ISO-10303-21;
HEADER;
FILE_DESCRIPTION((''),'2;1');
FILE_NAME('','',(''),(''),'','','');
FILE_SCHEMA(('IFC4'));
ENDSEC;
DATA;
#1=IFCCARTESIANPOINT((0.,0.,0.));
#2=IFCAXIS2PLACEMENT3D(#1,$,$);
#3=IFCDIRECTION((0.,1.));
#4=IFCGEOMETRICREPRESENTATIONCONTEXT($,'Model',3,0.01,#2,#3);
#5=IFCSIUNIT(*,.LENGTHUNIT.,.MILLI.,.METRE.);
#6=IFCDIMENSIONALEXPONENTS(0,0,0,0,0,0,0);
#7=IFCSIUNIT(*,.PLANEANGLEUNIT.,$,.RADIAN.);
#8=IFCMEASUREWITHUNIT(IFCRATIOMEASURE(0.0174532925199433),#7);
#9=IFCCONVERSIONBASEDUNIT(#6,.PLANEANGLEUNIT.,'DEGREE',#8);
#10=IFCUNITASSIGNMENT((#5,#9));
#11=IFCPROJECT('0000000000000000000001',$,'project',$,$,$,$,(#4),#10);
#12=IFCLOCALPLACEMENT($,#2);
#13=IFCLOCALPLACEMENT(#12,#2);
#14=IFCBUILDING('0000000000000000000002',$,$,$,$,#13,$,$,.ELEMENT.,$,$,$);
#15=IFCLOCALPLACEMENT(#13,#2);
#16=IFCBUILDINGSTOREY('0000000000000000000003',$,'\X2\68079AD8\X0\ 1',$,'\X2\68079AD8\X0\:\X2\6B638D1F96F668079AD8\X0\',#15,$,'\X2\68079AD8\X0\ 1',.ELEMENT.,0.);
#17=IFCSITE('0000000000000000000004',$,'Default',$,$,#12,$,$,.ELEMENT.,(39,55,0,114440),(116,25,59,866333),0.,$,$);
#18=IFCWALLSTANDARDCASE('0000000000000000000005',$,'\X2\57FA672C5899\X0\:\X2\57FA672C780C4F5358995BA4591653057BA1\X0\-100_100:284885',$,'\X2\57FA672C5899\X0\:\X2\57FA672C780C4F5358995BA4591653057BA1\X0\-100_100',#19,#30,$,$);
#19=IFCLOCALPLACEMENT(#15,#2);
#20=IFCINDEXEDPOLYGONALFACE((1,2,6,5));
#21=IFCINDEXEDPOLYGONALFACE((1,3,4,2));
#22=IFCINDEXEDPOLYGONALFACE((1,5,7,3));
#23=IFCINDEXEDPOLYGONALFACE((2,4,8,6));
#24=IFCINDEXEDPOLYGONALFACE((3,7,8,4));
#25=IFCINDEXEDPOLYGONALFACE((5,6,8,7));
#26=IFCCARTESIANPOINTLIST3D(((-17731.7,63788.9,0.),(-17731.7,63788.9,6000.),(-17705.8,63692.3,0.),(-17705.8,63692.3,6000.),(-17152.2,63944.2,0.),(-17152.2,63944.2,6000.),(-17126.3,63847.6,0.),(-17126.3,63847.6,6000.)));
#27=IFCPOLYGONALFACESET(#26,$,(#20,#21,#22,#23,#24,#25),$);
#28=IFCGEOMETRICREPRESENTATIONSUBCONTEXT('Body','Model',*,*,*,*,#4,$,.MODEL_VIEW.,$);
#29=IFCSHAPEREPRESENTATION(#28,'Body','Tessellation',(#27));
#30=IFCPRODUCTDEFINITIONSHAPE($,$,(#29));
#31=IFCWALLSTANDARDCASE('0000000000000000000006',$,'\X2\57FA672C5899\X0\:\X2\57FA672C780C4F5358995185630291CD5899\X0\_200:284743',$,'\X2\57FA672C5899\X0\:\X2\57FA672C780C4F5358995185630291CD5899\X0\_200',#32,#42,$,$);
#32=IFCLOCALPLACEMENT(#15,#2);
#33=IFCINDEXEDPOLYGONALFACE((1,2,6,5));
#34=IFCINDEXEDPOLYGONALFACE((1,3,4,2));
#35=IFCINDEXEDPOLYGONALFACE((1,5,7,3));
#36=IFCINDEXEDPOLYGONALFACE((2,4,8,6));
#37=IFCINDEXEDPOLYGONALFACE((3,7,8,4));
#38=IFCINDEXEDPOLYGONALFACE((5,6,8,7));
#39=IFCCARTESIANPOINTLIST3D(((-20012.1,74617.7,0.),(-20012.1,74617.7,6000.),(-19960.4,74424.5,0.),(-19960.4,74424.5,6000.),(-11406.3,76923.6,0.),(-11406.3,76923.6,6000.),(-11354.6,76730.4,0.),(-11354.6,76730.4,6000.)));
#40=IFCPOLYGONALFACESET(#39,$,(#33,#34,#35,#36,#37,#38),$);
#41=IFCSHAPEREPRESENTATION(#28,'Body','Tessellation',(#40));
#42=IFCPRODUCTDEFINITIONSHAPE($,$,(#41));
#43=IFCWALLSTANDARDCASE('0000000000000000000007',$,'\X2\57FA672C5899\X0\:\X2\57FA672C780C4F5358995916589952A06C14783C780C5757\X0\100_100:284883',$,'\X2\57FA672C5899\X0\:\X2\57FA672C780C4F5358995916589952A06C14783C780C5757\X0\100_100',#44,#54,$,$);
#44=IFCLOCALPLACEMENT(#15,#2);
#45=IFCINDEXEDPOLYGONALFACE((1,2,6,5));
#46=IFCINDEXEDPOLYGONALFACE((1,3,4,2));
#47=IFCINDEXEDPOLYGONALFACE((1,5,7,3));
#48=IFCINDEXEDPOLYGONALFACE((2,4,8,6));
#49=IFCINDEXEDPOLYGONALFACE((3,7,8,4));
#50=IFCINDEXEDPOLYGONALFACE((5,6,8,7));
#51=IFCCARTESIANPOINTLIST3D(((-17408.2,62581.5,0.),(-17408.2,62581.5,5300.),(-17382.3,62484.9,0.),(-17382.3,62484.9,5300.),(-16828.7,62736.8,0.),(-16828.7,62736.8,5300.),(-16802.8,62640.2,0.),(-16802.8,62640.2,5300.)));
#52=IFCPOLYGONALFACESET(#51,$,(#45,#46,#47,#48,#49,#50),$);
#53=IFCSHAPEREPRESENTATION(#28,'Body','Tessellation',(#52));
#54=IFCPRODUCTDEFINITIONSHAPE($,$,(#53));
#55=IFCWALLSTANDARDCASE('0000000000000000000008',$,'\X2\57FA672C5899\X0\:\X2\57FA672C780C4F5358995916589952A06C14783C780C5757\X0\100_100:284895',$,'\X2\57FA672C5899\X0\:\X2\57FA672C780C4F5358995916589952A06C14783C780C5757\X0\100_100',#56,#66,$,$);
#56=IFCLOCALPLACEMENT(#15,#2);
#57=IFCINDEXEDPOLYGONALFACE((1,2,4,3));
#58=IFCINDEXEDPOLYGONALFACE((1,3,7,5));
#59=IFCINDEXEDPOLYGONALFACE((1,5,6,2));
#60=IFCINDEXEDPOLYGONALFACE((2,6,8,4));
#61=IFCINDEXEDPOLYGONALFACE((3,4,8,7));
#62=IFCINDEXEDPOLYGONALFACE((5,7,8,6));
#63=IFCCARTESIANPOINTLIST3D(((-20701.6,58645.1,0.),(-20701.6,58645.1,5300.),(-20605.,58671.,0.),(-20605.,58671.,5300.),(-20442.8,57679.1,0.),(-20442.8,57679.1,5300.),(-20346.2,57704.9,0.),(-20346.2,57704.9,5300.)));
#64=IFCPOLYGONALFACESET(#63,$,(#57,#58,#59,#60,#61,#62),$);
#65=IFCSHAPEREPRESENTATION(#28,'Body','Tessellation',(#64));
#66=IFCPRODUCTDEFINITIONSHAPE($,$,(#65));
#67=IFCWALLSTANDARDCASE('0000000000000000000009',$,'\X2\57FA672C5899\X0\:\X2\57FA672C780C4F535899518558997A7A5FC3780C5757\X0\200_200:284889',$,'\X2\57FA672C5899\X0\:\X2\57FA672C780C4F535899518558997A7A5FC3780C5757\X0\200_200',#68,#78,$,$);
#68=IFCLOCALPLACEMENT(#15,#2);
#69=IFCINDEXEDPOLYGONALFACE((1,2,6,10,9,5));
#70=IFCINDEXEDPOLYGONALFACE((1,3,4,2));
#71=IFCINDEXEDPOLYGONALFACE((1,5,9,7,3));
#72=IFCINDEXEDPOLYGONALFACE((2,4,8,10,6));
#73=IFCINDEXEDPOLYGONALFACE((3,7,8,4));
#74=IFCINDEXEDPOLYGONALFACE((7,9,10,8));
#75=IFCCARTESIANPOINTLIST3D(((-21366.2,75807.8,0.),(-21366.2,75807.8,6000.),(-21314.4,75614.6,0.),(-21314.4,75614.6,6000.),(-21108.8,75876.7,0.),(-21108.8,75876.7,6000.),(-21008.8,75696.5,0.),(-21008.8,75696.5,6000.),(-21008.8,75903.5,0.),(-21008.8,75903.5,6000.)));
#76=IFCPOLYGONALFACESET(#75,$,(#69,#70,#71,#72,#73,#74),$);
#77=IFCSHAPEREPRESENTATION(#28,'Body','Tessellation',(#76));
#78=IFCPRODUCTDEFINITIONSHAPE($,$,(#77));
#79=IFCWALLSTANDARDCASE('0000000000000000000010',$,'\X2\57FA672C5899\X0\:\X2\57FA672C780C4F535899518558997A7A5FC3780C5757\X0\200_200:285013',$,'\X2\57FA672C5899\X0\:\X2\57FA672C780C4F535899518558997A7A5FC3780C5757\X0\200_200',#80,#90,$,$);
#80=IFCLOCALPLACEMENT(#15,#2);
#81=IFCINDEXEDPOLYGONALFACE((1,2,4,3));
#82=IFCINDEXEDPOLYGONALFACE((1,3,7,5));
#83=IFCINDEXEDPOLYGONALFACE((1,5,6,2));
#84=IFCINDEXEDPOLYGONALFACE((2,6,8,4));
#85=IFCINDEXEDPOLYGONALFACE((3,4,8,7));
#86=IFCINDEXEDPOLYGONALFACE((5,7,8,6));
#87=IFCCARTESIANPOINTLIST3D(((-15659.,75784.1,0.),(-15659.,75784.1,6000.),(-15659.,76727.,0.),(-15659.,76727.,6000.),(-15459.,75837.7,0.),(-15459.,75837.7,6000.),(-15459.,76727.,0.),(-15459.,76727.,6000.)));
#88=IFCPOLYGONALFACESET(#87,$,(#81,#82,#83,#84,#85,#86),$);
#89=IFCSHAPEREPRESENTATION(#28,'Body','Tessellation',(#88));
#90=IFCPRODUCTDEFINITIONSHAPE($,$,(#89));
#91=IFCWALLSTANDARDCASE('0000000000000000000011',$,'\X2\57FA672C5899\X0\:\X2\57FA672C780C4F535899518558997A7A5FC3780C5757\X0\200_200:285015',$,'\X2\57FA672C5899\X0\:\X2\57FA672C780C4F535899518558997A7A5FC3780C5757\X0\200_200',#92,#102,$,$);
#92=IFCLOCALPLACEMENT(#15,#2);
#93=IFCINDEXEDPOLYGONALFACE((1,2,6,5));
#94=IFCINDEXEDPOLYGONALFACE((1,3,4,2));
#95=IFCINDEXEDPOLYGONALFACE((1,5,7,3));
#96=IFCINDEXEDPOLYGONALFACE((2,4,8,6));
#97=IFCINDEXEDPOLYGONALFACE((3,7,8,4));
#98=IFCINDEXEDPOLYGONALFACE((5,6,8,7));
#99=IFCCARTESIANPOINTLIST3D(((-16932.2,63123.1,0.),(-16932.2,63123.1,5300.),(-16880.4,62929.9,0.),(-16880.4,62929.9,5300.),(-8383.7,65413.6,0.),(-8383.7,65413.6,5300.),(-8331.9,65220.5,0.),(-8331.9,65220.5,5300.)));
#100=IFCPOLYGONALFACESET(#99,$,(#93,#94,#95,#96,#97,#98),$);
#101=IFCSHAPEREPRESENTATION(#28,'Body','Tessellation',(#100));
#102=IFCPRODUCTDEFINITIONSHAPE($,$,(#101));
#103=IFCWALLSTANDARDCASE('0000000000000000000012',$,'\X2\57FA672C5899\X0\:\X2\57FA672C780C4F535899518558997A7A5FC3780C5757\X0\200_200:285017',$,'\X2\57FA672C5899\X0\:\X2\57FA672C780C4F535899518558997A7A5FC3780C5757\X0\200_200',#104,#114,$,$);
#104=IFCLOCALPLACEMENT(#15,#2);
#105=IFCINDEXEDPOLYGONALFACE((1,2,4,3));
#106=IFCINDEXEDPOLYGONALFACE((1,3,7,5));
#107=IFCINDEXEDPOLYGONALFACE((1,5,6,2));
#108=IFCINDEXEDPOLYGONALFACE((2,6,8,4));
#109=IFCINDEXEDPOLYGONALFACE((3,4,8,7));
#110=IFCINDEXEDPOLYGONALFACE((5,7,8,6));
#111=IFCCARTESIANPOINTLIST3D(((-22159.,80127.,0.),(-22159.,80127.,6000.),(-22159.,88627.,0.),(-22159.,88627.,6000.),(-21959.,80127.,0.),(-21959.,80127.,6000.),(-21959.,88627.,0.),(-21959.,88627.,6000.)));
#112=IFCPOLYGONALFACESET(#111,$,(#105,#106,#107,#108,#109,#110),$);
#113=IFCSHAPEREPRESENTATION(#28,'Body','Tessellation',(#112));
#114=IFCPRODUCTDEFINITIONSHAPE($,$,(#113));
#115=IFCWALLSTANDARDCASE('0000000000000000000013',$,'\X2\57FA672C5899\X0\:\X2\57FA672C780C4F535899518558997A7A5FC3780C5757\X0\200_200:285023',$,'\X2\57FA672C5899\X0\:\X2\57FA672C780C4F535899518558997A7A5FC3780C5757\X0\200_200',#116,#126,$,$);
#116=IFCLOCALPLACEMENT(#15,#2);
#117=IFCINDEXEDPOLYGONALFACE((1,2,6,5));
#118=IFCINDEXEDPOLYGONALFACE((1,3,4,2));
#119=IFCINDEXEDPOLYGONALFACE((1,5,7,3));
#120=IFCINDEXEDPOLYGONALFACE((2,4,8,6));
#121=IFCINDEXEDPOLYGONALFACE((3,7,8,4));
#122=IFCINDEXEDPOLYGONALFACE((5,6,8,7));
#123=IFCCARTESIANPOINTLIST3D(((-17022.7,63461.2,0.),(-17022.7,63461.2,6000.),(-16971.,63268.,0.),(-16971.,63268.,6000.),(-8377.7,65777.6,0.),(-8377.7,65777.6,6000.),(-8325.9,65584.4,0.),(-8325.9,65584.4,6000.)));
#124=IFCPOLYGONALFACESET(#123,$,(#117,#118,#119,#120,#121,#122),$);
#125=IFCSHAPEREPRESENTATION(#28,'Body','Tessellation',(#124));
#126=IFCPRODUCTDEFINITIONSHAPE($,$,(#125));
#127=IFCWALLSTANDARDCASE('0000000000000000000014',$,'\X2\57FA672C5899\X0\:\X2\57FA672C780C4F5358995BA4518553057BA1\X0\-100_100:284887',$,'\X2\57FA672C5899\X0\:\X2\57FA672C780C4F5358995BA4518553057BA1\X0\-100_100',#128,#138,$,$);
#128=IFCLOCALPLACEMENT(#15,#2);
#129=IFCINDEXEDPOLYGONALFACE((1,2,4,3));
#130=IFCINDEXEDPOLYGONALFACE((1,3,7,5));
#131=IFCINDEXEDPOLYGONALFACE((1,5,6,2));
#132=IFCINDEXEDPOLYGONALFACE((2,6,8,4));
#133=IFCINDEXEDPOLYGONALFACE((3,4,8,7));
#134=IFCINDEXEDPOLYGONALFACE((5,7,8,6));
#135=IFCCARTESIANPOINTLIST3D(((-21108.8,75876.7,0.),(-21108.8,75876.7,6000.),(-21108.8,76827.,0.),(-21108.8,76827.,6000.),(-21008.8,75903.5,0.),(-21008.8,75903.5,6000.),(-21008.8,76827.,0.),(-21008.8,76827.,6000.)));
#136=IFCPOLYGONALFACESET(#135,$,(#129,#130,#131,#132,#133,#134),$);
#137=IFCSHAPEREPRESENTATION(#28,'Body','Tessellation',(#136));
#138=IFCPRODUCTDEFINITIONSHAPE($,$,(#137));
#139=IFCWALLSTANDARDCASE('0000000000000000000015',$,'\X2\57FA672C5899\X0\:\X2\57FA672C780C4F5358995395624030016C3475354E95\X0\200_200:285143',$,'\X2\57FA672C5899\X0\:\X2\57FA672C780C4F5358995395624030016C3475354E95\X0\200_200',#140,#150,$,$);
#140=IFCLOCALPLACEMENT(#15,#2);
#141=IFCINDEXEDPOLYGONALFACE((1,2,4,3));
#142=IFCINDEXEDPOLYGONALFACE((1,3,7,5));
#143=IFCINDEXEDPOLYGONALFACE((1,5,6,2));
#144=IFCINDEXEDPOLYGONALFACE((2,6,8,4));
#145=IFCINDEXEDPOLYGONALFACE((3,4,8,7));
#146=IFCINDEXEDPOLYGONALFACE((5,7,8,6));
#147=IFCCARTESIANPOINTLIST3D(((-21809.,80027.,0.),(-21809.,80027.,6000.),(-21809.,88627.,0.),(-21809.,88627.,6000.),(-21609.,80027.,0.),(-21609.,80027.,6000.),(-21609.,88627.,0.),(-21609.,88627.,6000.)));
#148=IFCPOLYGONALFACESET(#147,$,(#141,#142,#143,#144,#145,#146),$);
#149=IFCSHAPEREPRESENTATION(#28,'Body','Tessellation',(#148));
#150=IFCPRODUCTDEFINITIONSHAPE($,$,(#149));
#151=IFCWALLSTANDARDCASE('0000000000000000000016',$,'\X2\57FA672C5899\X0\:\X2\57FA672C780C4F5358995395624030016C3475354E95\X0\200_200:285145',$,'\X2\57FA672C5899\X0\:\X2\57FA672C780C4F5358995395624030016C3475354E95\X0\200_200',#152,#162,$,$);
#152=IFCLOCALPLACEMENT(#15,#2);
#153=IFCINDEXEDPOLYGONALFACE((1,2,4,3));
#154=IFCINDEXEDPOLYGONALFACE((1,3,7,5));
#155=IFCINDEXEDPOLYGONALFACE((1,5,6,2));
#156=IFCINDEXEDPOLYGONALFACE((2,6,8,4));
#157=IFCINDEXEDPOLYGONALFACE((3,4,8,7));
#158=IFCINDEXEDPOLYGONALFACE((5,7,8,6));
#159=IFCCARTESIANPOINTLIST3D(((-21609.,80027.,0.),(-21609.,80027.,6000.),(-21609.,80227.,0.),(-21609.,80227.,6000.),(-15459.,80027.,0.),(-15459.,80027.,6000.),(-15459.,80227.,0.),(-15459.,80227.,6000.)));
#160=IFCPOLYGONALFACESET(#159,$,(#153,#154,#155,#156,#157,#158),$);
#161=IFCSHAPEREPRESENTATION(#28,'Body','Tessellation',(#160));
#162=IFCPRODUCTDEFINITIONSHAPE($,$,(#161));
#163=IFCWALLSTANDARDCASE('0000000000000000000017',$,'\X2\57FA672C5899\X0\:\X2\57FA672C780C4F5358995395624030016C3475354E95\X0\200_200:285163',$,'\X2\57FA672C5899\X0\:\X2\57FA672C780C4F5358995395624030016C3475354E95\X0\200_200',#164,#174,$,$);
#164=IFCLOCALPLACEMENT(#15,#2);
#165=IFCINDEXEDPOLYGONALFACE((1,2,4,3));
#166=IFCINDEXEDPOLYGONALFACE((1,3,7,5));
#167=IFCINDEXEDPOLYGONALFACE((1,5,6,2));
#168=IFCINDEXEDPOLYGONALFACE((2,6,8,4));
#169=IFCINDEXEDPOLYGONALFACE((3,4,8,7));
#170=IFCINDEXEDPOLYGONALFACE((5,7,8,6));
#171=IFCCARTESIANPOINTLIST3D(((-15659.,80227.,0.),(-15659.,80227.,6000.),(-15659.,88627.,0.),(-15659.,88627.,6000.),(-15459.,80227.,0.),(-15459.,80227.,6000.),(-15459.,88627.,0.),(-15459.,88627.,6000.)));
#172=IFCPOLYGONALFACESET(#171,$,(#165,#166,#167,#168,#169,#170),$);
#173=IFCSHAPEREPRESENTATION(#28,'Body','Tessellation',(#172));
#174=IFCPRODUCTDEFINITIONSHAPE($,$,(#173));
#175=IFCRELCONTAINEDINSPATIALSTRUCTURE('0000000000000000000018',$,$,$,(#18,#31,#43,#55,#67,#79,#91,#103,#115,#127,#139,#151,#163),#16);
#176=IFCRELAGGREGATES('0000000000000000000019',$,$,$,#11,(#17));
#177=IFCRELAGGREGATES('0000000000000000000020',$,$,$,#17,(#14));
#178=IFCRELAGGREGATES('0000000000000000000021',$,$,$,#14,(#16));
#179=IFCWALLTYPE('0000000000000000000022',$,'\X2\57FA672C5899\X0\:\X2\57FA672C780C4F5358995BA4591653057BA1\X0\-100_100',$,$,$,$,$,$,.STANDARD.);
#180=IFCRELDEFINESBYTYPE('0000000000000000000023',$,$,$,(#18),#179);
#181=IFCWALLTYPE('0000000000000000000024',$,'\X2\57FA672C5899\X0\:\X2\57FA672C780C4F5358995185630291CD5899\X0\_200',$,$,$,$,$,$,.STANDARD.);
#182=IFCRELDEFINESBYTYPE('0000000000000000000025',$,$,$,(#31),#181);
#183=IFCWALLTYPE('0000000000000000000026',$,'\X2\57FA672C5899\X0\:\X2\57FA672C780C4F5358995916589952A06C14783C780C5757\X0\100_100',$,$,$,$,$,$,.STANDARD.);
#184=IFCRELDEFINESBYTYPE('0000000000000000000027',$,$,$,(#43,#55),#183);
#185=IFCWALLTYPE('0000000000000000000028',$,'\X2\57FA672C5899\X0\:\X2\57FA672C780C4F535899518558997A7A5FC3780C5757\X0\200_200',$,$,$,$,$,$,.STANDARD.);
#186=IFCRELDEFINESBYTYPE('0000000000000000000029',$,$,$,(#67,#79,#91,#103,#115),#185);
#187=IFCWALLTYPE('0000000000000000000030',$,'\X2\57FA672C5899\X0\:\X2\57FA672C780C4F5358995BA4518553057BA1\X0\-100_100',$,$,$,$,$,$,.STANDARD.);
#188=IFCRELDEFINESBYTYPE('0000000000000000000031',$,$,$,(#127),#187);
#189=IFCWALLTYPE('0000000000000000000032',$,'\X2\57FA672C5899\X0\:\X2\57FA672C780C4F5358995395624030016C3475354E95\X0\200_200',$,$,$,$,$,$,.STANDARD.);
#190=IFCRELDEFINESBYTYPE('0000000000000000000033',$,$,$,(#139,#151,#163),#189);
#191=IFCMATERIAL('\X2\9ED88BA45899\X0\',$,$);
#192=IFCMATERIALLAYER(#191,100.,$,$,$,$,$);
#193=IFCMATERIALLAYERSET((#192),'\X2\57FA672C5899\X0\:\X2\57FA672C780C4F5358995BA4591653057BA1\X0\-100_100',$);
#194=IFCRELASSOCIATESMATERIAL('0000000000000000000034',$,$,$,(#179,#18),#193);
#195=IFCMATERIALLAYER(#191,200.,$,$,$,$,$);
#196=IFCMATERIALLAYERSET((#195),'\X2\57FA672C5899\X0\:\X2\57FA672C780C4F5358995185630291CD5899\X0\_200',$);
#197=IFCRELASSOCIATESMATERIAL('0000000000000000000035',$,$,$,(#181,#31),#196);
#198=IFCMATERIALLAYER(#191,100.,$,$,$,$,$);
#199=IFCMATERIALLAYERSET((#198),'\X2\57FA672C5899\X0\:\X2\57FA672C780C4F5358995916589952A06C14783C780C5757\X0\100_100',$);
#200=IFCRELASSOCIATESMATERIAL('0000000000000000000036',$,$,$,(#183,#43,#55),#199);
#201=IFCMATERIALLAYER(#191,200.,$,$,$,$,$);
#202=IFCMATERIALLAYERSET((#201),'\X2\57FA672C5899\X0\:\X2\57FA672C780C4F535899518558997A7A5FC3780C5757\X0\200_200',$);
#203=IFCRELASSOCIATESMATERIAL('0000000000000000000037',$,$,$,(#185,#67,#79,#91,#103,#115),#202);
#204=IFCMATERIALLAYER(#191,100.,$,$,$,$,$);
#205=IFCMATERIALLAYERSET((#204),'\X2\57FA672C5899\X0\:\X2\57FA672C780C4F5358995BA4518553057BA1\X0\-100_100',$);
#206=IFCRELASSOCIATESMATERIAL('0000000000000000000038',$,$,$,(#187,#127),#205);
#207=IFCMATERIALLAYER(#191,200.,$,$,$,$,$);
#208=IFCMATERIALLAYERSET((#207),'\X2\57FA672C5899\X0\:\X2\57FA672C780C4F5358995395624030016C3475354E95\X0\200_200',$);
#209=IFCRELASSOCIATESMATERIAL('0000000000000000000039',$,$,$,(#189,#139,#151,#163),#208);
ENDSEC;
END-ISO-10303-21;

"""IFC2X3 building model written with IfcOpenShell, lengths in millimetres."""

from ifc_helpers import new_model, entity, si_unit, converted_unit, direction, frame, frame_2d, origin, place, context, subcontext, project, spatial, polyline, rectangle, outline, extrude, material, layer, layer_set, layer_usage, type_object, element, save


model = new_model("IFC2X3")

# Units and contexts
model_context = context("Model", 3, precision=0.01, world=origin(), true_north=direction((0.0, 1.0)))
body_context = subcontext(model_context, "Body", "Model", "MODEL_VIEW")
ifc_project = project(units=[si_unit("LENGTHUNIT", "METRE", prefix="MILLI"), converted_unit("PLANEANGLEUNIT", "DEGREE", entity("IfcRatioMeasure", 0.0174532925199433), si_unit("PLANEANGLEUNIT", "RADIAN"), dimensions=[0, 0, 0, 0, 0, 0, 0])], contexts=[model_context])

# Site, building, storey
site_placement = place(None, origin())
site = spatial("IfcSite", under=ifc_project, at=site_placement, Name="Default", CompositionType="ELEMENT", RefLatitude=(39, 55, 0, 114440), RefLongitude=(116, 25, 59, 866333), RefElevation=0.0)
building_placement = place(site_placement, origin())
building = spatial("IfcBuilding", under=site, at=building_placement, CompositionType="ELEMENT")
storey_placement = place(building_placement, origin())
storey = spatial("IfcBuildingStorey", under=building, at=storey_placement, Name="标高 1", ObjectType="标高:正负零标高", LongName="标高 1", CompositionType="ELEMENT", Elevation=0.0)

# Walls
ifc_material = material(Name="默认墙")
ifc_layer_1 = layer(ifc_material, 100.0)
ifc_layer_set_1 = layer_set([ifc_layer_1], Name="基本墙:基本砌体墙室外包管-100_100")
ifc_layer_usage_1 = layer_usage(ifc_layer_set_1, "AXIS2", "NEGATIVE", 50.0)
wall_type_1 = type_object("IfcWallType", Name="基本墙:基本砌体墙室外包管-100_100", PredefinedType="STANDARD", material=ifc_layer_set_1)
wall_1_placement = place(building_placement, frame((-17718.8, 63740.6, 0.0), z_axis=(0.0, 0.0, 1.0), x_axis=(0.965926, 0.258819, 0.0)))
element("IfcWallStandardCase", 1, at=wall_1_placement, inside=storey, type_object=wall_type_1, material=ifc_layer_usage_1, Name="基本墙:基本砌体墙室外包管-100_100:284885", ObjectType="基本墙:基本砌体墙室外包管-100_100", context=body_context, shape_type="SweptSolid", body=[
    extrude(rectangle(XDim=600.0, YDim=100.0, at=frame_2d((300.0, 0.0), x_axis=(-1.0, 0.0))), origin(), (0.0, 0.0, 1.0), 6000.0),
])
ifc_layer_2 = layer(ifc_material, 200.0)
ifc_layer_set_2 = layer_set([ifc_layer_2], Name="基本墙:基本砌体墙内挂重墙_200")
ifc_layer_usage_2 = layer_usage(ifc_layer_set_2, "AXIS2", "NEGATIVE", 100.0)
wall_type_2 = type_object("IfcWallType", Name="基本墙:基本砌体墙内挂重墙_200", PredefinedType="STANDARD", material=ifc_layer_set_2)
wall_2_placement = place(building_placement, frame((-19986.2, 74521.1, 0.0), z_axis=(0.0, 0.0, 1.0), x_axis=(0.965926, 0.258819, 0.0)))
element("IfcWallStandardCase", 2, at=wall_2_placement, inside=storey, type_object=wall_type_2, material=ifc_layer_usage_2, Name="基本墙:基本砌体墙内挂重墙_200:284743", ObjectType="基本墙:基本砌体墙内挂重墙_200", context=body_context, shape_type="SweptSolid", body=[
    extrude(rectangle(XDim=8909.4, YDim=200.0, at=frame_2d((4454.7, 0.0), x_axis=(-1.0, 0.0))), origin(), (0.0, 0.0, 1.0), 6000.0),
])
ifc_layer_3 = layer(ifc_material, 100.0)
ifc_layer_set_3 = layer_set([ifc_layer_3], Name="基本墙:基本砌体墙外墙加气砼砌块100_100")
ifc_layer_usage_3 = layer_usage(ifc_layer_set_3, "AXIS2", "NEGATIVE", 50.0)
wall_type_3 = type_object("IfcWallType", Name="基本墙:基本砌体墙外墙加气砼砌块100_100", PredefinedType="STANDARD", material=ifc_layer_set_3)
wall_3_placement = place(building_placement, frame((-17395.3, 62533.2, 0.0), z_axis=(0.0, 0.0, 1.0), x_axis=(0.965926, 0.258819, 0.0)))
element("IfcWallStandardCase", 3, at=wall_3_placement, inside=storey, type_object=wall_type_3, material=ifc_layer_usage_3, Name="基本墙:基本砌体墙外墙加气砼砌块100_100:284883", ObjectType="基本墙:基本砌体墙外墙加气砼砌块100_100", context=body_context, shape_type="SweptSolid", body=[
    extrude(rectangle(XDim=600.0, YDim=100.0, at=frame_2d((300.0, 0.0), x_axis=(-1.0, 0.0))), origin(), (0.0, 0.0, 1.0), 5300.0),
])
ifc_layer_usage_4 = layer_usage(ifc_layer_set_3, "AXIS2", "NEGATIVE", 50.0)
wall_4_placement = place(building_placement, frame((-20394.5, 57692.0, 0.0), z_axis=(0.0, 0.0, 1.0), x_axis=(-0.258819, 0.965926, 0.0)))
element("IfcWallStandardCase", 4, at=wall_4_placement, inside=storey, type_object=wall_type_3, material=ifc_layer_usage_4, Name="基本墙:基本砌体墙外墙加气砼砌块100_100:284895", ObjectType="基本墙:基本砌体墙外墙加气砼砌块100_100", context=body_context, shape_type="SweptSolid", body=[
    extrude(rectangle(XDim=1000.1, YDim=100.0, at=frame_2d((500.0, 0.0), x_axis=(-1.0, 0.0))), origin(), (0.0, 0.0, 1.0), 5300.0),
])
ifc_layer_4 = layer(ifc_material, 200.0)
ifc_layer_set_4 = layer_set([ifc_layer_4], Name="基本墙:基本砌体墙内墙空心砌块200_200")
ifc_layer_usage_5 = layer_usage(ifc_layer_set_4, "AXIS2", "NEGATIVE", 100.0)
wall_type_4 = type_object("IfcWallType", Name="基本墙:基本砌体墙内墙空心砌块200_200", PredefinedType="STANDARD", material=ifc_layer_set_4)
wall_5_placement = place(building_placement, frame((-21340.3, 75711.2, 0.0), z_axis=(0.0, 0.0, 1.0), x_axis=(0.965926, 0.258819, 0.0)))
element("IfcWallStandardCase", 5, at=wall_5_placement, inside=storey, type_object=wall_type_4, material=ifc_layer_usage_5, Name="基本墙:基本砌体墙内墙空心砌块200_200:284889", ObjectType="基本墙:基本砌体墙内墙空心砌块200_200", context=body_context, shape_type="SweptSolid", body=[
    extrude(outline(polyline([(316.4, -100.0), (370.0, 100.0), (266.4, 100.0), (0.0, 100.0), (0.0, -100.0), (316.4, -100.0)])), origin(), (0.0, 0.0, 1.0), 6000.0),
])
ifc_layer_usage_6 = layer_usage(ifc_layer_set_4, "AXIS2", "NEGATIVE", 100.0)
wall_6_placement = place(building_placement, frame((-15559.0, 75784.1, 0.0), z_axis=(0.0, 0.0, 1.0), x_axis=(0.0, 1.0, 0.0)))
element("IfcWallStandardCase", 6, at=wall_6_placement, inside=storey, type_object=wall_type_4, material=ifc_layer_usage_6, Name="基本墙:基本砌体墙内墙空心砌块200_200:285013", ObjectType="基本墙:基本砌体墙内墙空心砌块200_200", context=body_context, shape_type="SweptSolid", body=[
    extrude(outline(polyline([(942.9, -100.0), (942.9, 100.0), (0.0, 100.0), (53.6, -100.0), (942.9, -100.0)])), origin(), (0.0, 0.0, 1.0), 6000.0),
])
ifc_layer_usage_7 = layer_usage(ifc_layer_set_4, "AXIS2", "NEGATIVE", 100.0)
wall_7_placement = place(building_placement, frame((-8357.8, 65317.0, 0.0), z_axis=(0.0, 0.0, 1.0), x_axis=(-0.965926, -0.258819, 0.0)))
element("IfcWallStandardCase", 7, at=wall_7_placement, inside=storey, type_object=wall_type_4, material=ifc_layer_usage_7, Name="基本墙:基本砌体墙内墙空心砌块200_200:285015", ObjectType="基本墙:基本砌体墙内墙空心砌块200_200", context=body_context, shape_type="SweptSolid", body=[
    extrude(rectangle(XDim=8850.0, YDim=200.0, at=frame_2d((4425.0, 0.0), x_axis=(-1.0, 0.0))), origin(), (0.0, 0.0, 1.0), 5300.0),
])
ifc_layer_usage_8 = layer_usage(ifc_layer_set_4, "AXIS2", "NEGATIVE", 100.0)
wall_8_placement = place(building_placement, frame((-22059.0, 80127.0, 0.0), z_axis=(0.0, 0.0, 1.0), x_axis=(0.0, 1.0, 0.0)))
element("IfcWallStandardCase", 8, at=wall_8_placement, inside=storey, type_object=wall_type_4, material=ifc_layer_usage_8, Name="基本墙:基本砌体墙内墙空心砌块200_200:285017", ObjectType="基本墙:基本砌体墙内墙空心砌块200_200", context=body_context, shape_type="SweptSolid", body=[
    extrude(rectangle(XDim=8500.0, YDim=200.0, at=frame_2d((4250.0, 0.0), x_axis=(-1.0, 0.0))), origin(), (0.0, 0.0, 1.0), 6000.0),
])
ifc_layer_usage_9 = layer_usage(ifc_layer_set_4, "AXIS2", "NEGATIVE", 100.0)
wall_9_placement = place(building_placement, frame((-16996.9, 63364.6, 0.0), z_axis=(0.0, 0.0, 1.0), x_axis=(0.965926, 0.258819, 0.0)))
element("IfcWallStandardCase", 9, at=wall_9_placement, inside=storey, type_object=wall_type_4, material=ifc_layer_usage_9, Name="基本墙:基本砌体墙内墙空心砌块200_200:285023", ObjectType="基本墙:基本砌体墙内墙空心砌块200_200", context=body_context, shape_type="SweptSolid", body=[
    extrude(rectangle(XDim=8950.0, YDim=200.0, at=frame_2d((4475.0, 0.0), x_axis=(-1.0, 0.0))), origin(), (0.0, 0.0, 1.0), 6000.0),
])
ifc_layer_5 = layer(ifc_material, 100.0)
ifc_layer_set_5 = layer_set([ifc_layer_5], Name="基本墙:基本砌体墙室内包管-100_100")
ifc_layer_usage_10 = layer_usage(ifc_layer_set_5, "AXIS2", "NEGATIVE", 50.0)
wall_type_5 = type_object("IfcWallType", Name="基本墙:基本砌体墙室内包管-100_100", PredefinedType="STANDARD", material=ifc_layer_set_5)
wall_10_placement = place(building_placement, frame((-21058.8, 75876.7, 0.0), z_axis=(0.0, 0.0, 1.0), x_axis=(0.0, 1.0, 0.0)))
element("IfcWallStandardCase", 10, at=wall_10_placement, inside=storey, type_object=wall_type_5, material=ifc_layer_usage_10, Name="基本墙:基本砌体墙室内包管-100_100:284887", ObjectType="基本墙:基本砌体墙室内包管-100_100", context=body_context, shape_type="SweptSolid", body=[
    extrude(outline(polyline([(950.3, -50.0), (950.3, 50.0), (0.0, 50.0), (26.8, -50.0), (950.3, -50.0)])), origin(), (0.0, 0.0, 1.0), 6000.0),
])
ifc_layer_6 = layer(ifc_material, 200.0)
ifc_layer_set_6 = layer_set([ifc_layer_6], Name="基本墙:基本砌体墙厕所、水电井200_200")
ifc_layer_usage_11 = layer_usage(ifc_layer_set_6, "AXIS2", "NEGATIVE", 100.0)
wall_type_6 = type_object("IfcWallType", Name="基本墙:基本砌体墙厕所、水电井200_200", PredefinedType="STANDARD", material=ifc_layer_set_6)
wall_11_placement = place(building_placement, frame((-21709.0, 80027.0, 0.0), z_axis=(0.0, 0.0, 1.0), x_axis=(0.0, 1.0, 0.0)))
element("IfcWallStandardCase", 11, at=wall_11_placement, inside=storey, type_object=wall_type_6, material=ifc_layer_usage_11, Name="基本墙:基本砌体墙厕所、水电井200_200:285143", ObjectType="基本墙:基本砌体墙厕所、水电井200_200", context=body_context, shape_type="SweptSolid", body=[
    extrude(rectangle(XDim=8600.0, YDim=200.0, at=frame_2d((4300.0, 0.0), x_axis=(-1.0, 0.0))), origin(), (0.0, 0.0, 1.0), 6000.0),
])
ifc_layer_usage_12 = layer_usage(ifc_layer_set_6, "AXIS2", "NEGATIVE", 100.0)
wall_12_placement = place(building_placement, frame((-21609.0, 80127.0, 0.0)))
element("IfcWallStandardCase", 12, at=wall_12_placement, inside=storey, type_object=wall_type_6, material=ifc_layer_usage_12, Name="基本墙:基本砌体墙厕所、水电井200_200:285145", ObjectType="基本墙:基本砌体墙厕所、水电井200_200", context=body_context, shape_type="SweptSolid", body=[
    extrude(rectangle(XDim=6150.0, YDim=200.0, at=frame_2d((3075.0, 0.0), x_axis=(-1.0, 0.0))), origin(), (0.0, 0.0, 1.0), 6000.0),
])
ifc_layer_usage_13 = layer_usage(ifc_layer_set_6, "AXIS2", "NEGATIVE", 100.0)
wall_13_placement = place(building_placement, frame((-15559.0, 80227.0, 0.0), z_axis=(0.0, 0.0, 1.0), x_axis=(0.0, 1.0, 0.0)))
element("IfcWallStandardCase", 13, at=wall_13_placement, inside=storey, type_object=wall_type_6, material=ifc_layer_usage_13, Name="基本墙:基本砌体墙厕所、水电井200_200:285163", ObjectType="基本墙:基本砌体墙厕所、水电井200_200", context=body_context, shape_type="SweptSolid", body=[
    extrude(rectangle(XDim=8400.0, YDim=200.0, at=frame_2d((4200.0, 0.0), x_axis=(-1.0, 0.0))), origin(), (0.0, 0.0, 1.0), 6000.0),
])

save(model, "model.ifc")
